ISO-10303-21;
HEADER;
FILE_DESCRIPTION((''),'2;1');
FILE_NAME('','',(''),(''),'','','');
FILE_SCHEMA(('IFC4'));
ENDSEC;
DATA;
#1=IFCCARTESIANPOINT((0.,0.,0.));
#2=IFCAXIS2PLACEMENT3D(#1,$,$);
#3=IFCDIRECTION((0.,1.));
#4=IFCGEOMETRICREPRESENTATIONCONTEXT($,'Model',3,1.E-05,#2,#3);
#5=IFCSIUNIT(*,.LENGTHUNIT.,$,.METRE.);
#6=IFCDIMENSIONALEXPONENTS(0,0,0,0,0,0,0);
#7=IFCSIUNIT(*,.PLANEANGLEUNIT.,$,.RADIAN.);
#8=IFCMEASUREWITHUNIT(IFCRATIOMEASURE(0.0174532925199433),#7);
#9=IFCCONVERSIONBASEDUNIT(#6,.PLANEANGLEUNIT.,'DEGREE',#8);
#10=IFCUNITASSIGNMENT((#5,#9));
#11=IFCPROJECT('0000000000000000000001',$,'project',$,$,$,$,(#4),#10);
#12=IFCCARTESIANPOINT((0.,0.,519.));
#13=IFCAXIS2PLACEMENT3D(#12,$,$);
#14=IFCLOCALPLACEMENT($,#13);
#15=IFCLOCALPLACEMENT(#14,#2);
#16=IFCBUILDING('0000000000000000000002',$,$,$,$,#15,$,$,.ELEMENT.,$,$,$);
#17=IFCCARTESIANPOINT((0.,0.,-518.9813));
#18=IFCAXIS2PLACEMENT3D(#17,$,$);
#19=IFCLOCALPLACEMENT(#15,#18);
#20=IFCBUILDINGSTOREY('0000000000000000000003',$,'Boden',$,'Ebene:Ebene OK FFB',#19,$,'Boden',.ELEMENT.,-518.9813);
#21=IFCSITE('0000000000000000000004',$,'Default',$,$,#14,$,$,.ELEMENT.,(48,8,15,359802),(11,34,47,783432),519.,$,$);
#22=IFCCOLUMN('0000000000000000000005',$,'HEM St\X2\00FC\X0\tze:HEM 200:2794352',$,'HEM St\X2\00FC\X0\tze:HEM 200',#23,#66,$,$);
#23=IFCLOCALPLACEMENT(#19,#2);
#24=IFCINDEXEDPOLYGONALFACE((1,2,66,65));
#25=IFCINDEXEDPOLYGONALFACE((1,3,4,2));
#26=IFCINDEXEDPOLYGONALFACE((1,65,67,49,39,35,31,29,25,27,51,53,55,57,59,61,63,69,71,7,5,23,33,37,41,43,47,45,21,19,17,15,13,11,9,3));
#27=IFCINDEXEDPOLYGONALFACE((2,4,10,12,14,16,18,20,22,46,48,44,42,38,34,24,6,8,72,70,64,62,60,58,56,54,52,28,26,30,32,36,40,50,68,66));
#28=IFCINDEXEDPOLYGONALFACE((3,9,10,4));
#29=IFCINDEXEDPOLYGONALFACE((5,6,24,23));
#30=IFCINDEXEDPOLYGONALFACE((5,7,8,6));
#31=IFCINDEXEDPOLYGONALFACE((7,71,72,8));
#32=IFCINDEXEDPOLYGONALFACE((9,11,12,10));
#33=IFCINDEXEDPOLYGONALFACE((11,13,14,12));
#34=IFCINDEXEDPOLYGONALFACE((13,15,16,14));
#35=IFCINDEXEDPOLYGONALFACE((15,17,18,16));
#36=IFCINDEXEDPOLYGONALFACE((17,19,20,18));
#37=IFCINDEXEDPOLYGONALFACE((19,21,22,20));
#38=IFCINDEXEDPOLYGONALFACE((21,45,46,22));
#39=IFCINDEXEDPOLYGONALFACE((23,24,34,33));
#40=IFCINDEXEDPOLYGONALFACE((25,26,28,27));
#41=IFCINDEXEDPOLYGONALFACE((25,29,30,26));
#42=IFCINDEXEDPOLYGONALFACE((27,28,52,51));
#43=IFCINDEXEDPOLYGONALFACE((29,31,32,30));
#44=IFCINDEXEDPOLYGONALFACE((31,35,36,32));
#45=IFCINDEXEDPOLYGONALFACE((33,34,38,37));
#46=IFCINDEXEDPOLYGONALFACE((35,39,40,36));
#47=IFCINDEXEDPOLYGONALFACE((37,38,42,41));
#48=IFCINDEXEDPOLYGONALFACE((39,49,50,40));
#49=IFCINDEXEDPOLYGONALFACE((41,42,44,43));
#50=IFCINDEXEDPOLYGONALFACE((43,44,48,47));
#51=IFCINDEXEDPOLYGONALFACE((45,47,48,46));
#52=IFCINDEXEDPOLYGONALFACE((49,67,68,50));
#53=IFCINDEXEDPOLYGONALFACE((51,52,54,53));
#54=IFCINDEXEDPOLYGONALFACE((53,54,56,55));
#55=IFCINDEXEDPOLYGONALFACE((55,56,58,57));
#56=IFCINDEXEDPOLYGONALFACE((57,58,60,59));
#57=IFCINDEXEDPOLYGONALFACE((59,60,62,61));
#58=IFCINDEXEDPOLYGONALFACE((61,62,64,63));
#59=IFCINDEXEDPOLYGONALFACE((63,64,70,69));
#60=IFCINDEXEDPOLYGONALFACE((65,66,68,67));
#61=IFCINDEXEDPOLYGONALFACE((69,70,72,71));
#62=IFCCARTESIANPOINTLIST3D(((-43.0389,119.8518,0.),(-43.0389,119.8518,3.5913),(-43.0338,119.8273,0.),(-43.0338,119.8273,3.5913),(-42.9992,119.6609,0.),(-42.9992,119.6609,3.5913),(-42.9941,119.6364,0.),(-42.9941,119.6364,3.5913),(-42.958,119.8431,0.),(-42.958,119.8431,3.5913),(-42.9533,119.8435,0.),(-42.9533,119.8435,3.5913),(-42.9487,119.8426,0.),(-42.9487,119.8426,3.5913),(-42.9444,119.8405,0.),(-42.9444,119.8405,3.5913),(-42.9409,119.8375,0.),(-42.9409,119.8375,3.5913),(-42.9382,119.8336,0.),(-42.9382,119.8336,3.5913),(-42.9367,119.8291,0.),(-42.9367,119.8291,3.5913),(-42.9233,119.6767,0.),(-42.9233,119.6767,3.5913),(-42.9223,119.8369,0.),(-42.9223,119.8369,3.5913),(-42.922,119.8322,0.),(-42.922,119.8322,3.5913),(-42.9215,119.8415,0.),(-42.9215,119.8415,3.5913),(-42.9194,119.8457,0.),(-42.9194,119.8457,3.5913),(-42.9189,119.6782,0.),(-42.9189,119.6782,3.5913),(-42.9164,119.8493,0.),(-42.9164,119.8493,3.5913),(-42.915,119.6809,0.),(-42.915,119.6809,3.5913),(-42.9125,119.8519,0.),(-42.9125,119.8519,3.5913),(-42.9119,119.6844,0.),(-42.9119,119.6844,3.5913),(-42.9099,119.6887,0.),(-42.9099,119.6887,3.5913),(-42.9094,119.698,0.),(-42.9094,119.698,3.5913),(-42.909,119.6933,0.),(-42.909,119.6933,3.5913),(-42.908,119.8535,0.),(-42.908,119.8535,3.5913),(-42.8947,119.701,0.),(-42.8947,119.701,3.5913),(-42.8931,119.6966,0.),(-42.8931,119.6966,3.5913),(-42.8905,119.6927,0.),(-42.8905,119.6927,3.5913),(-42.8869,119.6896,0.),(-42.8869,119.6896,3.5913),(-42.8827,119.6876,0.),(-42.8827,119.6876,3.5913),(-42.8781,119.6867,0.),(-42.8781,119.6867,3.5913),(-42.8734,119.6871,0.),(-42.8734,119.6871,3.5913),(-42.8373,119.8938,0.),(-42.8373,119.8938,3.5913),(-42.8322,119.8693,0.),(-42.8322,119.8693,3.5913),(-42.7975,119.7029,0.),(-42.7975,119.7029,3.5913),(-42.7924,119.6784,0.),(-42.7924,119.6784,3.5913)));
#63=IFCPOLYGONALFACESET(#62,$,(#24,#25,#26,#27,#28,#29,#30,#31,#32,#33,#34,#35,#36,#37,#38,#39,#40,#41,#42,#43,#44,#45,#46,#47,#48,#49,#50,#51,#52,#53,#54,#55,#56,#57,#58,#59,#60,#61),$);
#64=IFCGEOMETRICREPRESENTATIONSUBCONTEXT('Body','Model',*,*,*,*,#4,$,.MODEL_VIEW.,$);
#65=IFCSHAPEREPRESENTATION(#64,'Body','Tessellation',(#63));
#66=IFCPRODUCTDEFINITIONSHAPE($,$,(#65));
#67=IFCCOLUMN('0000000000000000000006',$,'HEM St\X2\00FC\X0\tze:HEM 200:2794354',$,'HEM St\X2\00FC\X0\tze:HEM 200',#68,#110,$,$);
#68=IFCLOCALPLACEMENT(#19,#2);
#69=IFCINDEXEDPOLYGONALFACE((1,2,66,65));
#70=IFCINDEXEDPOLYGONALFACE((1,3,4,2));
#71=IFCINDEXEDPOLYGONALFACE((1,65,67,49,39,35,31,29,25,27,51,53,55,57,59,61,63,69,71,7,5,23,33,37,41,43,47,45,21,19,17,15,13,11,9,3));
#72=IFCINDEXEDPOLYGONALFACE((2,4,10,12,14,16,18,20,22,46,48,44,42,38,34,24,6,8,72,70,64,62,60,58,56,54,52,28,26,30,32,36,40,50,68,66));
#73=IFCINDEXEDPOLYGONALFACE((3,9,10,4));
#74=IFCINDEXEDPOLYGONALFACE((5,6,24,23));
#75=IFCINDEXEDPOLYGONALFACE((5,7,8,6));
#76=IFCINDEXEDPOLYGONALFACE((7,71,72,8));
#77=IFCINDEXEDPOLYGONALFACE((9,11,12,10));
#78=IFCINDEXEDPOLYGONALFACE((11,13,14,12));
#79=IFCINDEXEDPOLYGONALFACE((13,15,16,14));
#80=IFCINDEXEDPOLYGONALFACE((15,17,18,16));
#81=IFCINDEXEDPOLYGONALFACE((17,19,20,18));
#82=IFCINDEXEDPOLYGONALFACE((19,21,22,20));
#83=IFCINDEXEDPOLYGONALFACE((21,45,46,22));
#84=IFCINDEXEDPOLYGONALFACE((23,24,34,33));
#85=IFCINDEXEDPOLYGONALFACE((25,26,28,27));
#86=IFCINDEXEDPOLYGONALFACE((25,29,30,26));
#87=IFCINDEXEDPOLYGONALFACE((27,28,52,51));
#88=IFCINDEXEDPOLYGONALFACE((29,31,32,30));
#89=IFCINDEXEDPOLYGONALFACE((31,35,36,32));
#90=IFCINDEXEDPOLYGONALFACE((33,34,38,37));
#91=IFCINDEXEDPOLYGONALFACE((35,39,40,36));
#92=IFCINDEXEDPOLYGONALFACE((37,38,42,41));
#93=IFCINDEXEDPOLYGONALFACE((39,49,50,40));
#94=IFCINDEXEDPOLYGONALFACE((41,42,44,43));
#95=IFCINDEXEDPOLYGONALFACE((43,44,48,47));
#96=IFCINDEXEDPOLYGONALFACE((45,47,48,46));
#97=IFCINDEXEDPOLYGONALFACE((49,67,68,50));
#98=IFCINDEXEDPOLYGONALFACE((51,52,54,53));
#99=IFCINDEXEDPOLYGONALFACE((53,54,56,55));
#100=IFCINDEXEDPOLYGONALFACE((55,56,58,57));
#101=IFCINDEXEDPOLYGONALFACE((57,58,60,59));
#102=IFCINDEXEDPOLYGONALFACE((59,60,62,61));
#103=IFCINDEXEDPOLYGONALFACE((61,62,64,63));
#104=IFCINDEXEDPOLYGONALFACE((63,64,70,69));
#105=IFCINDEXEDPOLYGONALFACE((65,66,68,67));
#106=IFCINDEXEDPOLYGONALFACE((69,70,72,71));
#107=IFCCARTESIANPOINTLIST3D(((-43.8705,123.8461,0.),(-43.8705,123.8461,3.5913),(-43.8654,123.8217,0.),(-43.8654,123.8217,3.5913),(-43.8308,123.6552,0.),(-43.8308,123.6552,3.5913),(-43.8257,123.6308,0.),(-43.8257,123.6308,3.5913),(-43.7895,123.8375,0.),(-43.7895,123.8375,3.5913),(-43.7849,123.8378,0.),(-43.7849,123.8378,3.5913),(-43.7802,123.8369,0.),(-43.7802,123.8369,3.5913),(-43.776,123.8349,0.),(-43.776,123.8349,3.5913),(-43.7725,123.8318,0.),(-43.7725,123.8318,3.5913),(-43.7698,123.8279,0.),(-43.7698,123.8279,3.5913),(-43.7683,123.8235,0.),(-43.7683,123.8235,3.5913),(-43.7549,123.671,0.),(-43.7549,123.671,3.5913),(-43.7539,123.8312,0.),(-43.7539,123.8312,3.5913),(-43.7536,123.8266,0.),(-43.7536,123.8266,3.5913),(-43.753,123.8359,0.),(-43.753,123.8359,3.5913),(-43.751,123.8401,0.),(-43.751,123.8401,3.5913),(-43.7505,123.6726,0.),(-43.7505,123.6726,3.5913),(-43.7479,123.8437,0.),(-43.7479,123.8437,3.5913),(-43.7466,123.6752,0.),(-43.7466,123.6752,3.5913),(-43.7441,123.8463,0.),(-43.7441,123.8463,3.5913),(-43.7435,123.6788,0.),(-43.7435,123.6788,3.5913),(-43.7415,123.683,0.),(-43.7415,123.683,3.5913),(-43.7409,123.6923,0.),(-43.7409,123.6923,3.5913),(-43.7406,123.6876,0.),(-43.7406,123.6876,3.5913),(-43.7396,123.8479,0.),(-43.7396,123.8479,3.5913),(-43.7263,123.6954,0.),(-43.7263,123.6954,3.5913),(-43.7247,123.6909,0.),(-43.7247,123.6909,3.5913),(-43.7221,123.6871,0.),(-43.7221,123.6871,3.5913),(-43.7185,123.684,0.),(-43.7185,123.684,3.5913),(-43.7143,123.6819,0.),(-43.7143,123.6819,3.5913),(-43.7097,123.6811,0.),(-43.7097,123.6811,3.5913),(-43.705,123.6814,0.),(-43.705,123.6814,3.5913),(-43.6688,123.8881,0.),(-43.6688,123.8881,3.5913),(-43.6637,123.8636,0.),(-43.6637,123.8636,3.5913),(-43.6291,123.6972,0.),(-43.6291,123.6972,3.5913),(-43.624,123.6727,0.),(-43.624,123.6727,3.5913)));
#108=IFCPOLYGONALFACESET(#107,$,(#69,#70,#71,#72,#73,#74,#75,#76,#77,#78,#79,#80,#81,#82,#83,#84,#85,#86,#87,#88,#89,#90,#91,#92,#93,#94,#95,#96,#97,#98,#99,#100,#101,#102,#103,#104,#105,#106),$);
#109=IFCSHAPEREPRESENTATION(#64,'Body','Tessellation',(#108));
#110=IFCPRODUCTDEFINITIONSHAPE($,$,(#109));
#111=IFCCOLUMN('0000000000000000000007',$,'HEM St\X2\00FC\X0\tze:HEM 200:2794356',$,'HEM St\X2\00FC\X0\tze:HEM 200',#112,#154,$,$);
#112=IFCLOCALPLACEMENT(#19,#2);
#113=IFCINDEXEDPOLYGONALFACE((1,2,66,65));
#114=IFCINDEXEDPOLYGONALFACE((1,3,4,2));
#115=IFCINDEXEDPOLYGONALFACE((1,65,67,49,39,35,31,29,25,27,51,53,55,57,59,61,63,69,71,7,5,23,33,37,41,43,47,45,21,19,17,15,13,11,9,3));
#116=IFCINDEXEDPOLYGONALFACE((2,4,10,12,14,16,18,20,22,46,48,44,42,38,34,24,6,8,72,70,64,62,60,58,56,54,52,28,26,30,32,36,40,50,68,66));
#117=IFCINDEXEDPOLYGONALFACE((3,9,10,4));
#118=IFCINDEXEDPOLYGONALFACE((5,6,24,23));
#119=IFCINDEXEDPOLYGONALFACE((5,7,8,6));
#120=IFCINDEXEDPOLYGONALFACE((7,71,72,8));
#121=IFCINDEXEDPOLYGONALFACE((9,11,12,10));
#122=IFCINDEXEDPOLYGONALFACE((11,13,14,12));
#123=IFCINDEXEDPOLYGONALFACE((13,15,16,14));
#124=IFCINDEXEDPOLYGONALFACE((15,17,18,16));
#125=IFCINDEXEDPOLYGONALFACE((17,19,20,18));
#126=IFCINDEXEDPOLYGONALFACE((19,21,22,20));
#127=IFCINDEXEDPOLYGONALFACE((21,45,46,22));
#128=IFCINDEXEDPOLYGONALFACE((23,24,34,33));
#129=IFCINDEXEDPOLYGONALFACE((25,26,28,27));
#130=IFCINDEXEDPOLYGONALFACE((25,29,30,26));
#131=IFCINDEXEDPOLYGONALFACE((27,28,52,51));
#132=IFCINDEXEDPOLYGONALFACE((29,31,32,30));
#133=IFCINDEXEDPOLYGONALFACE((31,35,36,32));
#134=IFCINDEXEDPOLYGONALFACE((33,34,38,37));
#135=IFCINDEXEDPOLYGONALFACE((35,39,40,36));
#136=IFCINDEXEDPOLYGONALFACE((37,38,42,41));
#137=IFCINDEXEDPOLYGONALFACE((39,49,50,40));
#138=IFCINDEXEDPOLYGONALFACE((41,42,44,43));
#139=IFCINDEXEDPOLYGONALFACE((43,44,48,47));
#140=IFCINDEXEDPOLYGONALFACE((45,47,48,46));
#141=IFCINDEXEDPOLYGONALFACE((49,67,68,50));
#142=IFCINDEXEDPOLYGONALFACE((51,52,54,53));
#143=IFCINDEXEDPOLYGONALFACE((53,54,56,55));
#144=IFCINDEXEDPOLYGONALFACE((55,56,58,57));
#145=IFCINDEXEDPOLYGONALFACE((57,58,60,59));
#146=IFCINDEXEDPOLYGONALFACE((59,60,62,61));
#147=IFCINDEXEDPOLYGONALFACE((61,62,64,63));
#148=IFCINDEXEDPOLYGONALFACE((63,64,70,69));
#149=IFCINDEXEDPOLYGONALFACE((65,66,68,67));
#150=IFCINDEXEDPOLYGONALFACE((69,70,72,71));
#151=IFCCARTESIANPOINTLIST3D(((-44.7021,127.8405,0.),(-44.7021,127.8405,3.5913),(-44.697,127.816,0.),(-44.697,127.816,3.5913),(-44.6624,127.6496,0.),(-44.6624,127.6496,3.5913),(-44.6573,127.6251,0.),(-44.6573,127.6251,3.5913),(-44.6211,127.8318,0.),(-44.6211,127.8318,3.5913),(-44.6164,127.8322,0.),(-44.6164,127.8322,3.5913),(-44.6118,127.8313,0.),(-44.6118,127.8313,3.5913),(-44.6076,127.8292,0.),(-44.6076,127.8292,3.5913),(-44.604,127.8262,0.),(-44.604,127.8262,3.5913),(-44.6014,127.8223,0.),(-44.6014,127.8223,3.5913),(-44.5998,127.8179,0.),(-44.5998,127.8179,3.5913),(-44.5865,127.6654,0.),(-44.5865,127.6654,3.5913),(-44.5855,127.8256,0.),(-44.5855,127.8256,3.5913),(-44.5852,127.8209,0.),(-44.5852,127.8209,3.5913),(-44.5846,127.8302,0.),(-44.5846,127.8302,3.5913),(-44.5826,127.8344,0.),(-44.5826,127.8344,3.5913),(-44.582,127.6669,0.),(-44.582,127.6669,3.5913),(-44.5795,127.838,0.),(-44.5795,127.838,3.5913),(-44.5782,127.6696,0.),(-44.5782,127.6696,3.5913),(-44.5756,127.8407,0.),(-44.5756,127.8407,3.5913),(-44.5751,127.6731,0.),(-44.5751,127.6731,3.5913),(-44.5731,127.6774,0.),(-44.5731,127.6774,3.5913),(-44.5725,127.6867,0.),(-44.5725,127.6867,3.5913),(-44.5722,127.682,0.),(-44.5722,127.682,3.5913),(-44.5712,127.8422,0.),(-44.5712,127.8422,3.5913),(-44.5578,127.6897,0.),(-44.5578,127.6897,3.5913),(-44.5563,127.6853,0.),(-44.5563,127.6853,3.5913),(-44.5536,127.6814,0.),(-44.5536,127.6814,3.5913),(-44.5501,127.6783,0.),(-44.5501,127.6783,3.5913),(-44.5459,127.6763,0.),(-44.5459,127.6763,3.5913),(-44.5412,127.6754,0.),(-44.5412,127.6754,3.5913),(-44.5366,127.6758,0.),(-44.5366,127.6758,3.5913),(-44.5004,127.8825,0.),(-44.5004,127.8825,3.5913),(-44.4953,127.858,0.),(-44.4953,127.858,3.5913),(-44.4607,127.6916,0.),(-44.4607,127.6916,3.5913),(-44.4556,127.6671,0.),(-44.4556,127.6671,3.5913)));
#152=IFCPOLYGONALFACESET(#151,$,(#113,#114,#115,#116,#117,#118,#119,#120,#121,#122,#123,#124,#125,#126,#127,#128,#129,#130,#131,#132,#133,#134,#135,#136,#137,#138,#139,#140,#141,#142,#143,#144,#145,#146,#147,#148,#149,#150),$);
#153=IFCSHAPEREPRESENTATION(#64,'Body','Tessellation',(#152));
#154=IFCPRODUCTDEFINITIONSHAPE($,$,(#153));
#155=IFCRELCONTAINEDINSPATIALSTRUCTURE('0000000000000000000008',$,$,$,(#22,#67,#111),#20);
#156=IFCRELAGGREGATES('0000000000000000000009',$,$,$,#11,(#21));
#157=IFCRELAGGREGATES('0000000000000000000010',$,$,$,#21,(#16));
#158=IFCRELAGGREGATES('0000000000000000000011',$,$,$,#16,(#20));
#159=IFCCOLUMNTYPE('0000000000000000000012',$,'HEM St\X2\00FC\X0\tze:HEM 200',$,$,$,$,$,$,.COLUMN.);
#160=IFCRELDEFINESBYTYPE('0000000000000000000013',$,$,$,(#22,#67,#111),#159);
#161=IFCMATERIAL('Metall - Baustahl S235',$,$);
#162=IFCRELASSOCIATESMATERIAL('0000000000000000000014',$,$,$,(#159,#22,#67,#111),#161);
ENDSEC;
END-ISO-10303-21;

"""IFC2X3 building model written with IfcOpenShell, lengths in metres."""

from ifc_helpers import new_model, entity, si_unit, converted_unit, direction, frame, frame_2d, origin, place, context, subcontext, project, spatial, polyline, circle_curve, parameter, trimmed, segment, composite_curve, outline, extrude, source, transform, mapped, material, type_object, type_shapes, element, save


model = new_model("IFC2X3")

# Units and contexts
model_context = context("Model", 3, precision=1e-05, world=origin(), true_north=direction((0.0, 1.0)))
body_context = subcontext(model_context, "Body", "Model", "MODEL_VIEW")
ifc_project = project(units=[si_unit("LENGTHUNIT", "METRE"), converted_unit("PLANEANGLEUNIT", "DEGREE", entity("IfcRatioMeasure", 0.0174532925199433), si_unit("PLANEANGLEUNIT", "RADIAN"), dimensions=[0, 0, 0, 0, 0, 0, 0])], contexts=[model_context])

# Site, building, storey
site_placement = place(None, frame((0.0, 0.0, 519.0)))
site = spatial("IfcSite", under=ifc_project, at=site_placement, Name="Default", CompositionType="ELEMENT", RefLatitude=(48, 8, 15, 359802), RefLongitude=(11, 34, 47, 783432), RefElevation=519.0)
building_placement = place(site_placement, origin())
building = spatial("IfcBuilding", under=site, at=building_placement, CompositionType="ELEMENT")
storey_placement = place(building_placement, frame((0.0, 0.0, -518.9813)))
storey = spatial("IfcBuildingStorey", under=building, at=storey_placement, Name="Boden", ObjectType="Ebene:Ebene OK FFB", LongName="Boden", CompositionType="ELEMENT", Elevation=-518.9813)

# Columns
ifc_material = material(Name="Metall - Baustahl S235")
column_type = type_object("IfcColumnType", Name="HEM Stütze:HEM 200", PredefinedType="COLUMN", material=ifc_material)
shared_shape = source(origin(), body_context, "Body", "SweptSolid", [
    extrude(outline(composite_curve([segment(polyline([(0.085, -0.103), (0.11, -0.103)]), True, "CONTINUOUS"), segment(polyline([(0.11, -0.103), (0.11, 0.103)]), True, "CONTINUOUS"), segment(polyline([(0.11, 0.103), (0.085, 0.103)]), True, "CONTINUOUS"), segment(polyline([(0.085, 0.103), (0.085, 0.0255)]), True, "CONTINUOUS"), segment(trimmed(circle_curve(frame_2d((0.067, 0.0255), x_axis=(1.0, 0.0)), 0.018), [parameter(270.0)], [parameter(0.0)], True, "PARAMETER"), False, "CONTINUOUS"), segment(polyline([(0.067, 0.0075), (-0.067, 0.0075)]), True, "CONTINUOUS"), segment(trimmed(circle_curve(frame_2d((-0.067, 0.0255), x_axis=(0.0, -1.0)), 0.018), [parameter(270.0)], [parameter(0.0)], True, "PARAMETER"), False, "CONTINUOUS"), segment(polyline([(-0.085, 0.0255), (-0.085, 0.103)]), True, "CONTINUOUS"), segment(polyline([(-0.085, 0.103), (-0.11, 0.103)]), True, "CONTINUOUS"), segment(polyline([(-0.11, 0.103), (-0.11, -0.103)]), True, "CONTINUOUS"), segment(polyline([(-0.11, -0.103), (-0.085, -0.103)]), True, "CONTINUOUS"), segment(polyline([(-0.085, -0.103), (-0.085, -0.0255)]), True, "CONTINUOUS"), segment(trimmed(circle_curve(frame_2d((-0.067, -0.0255), x_axis=(-1.0, 0.0)), 0.018), [parameter(270.0)], [parameter(0.0)], True, "PARAMETER"), False, "CONTINUOUS"), segment(polyline([(-0.067, -0.0075), (0.067, -0.0075)]), True, "CONTINUOUS"), segment(trimmed(circle_curve(frame_2d((0.067, -0.0255), x_axis=(0.0, 1.0)), 0.018), [parameter(270.0)], [parameter(0.0)], True, "PARAMETER"), False, "CONTINUOUS"), segment(polyline([(0.085, -0.0255), (0.085, -0.103)]), True, "CONTINUOUS")], self_intersect=False)), frame((0.0, 0.0, -518.9813), z_axis=(0.0, 0.0, 1.0), x_axis=(0.0, -1.0, 0.0)), (0.0, 0.0, 1.0), 3.5913),
])
type_shapes(column_type, [shared_shape])
for number, where, z_axis, x_axis, name in (
    (1, (-42.9157, 119.7651, 518.9813), (0.0, 0.0, 1.0), (0.979008, 0.20382, 0.0), "HEM Stütze:HEM 200:2794352"),
    (2, (-43.7473, 123.7594, 518.9813), (0.0, 0.0, 1.0), (0.979008, 0.20382, 0.0), "HEM Stütze:HEM 200:2794354"),
    (3, (-44.5788, 127.7538, 518.9813), (0.0, 0.0, 1.0), (0.979008, 0.20382, 0.0), "HEM Stütze:HEM 200:2794356"),
):
    element("IfcColumn", number, at=place(storey_placement, frame(where, z_axis=z_axis, x_axis=x_axis)), inside=storey, type_object=column_type, material=ifc_material, Name=name, ObjectType="HEM Stütze:HEM 200", context=body_context, shape_type="MappedRepresentation", body=[
        mapped(shared_shape, transform((0.0, 0.0, 0.0), scale=1.0)),
    ])

save(model, "model.ifc")
